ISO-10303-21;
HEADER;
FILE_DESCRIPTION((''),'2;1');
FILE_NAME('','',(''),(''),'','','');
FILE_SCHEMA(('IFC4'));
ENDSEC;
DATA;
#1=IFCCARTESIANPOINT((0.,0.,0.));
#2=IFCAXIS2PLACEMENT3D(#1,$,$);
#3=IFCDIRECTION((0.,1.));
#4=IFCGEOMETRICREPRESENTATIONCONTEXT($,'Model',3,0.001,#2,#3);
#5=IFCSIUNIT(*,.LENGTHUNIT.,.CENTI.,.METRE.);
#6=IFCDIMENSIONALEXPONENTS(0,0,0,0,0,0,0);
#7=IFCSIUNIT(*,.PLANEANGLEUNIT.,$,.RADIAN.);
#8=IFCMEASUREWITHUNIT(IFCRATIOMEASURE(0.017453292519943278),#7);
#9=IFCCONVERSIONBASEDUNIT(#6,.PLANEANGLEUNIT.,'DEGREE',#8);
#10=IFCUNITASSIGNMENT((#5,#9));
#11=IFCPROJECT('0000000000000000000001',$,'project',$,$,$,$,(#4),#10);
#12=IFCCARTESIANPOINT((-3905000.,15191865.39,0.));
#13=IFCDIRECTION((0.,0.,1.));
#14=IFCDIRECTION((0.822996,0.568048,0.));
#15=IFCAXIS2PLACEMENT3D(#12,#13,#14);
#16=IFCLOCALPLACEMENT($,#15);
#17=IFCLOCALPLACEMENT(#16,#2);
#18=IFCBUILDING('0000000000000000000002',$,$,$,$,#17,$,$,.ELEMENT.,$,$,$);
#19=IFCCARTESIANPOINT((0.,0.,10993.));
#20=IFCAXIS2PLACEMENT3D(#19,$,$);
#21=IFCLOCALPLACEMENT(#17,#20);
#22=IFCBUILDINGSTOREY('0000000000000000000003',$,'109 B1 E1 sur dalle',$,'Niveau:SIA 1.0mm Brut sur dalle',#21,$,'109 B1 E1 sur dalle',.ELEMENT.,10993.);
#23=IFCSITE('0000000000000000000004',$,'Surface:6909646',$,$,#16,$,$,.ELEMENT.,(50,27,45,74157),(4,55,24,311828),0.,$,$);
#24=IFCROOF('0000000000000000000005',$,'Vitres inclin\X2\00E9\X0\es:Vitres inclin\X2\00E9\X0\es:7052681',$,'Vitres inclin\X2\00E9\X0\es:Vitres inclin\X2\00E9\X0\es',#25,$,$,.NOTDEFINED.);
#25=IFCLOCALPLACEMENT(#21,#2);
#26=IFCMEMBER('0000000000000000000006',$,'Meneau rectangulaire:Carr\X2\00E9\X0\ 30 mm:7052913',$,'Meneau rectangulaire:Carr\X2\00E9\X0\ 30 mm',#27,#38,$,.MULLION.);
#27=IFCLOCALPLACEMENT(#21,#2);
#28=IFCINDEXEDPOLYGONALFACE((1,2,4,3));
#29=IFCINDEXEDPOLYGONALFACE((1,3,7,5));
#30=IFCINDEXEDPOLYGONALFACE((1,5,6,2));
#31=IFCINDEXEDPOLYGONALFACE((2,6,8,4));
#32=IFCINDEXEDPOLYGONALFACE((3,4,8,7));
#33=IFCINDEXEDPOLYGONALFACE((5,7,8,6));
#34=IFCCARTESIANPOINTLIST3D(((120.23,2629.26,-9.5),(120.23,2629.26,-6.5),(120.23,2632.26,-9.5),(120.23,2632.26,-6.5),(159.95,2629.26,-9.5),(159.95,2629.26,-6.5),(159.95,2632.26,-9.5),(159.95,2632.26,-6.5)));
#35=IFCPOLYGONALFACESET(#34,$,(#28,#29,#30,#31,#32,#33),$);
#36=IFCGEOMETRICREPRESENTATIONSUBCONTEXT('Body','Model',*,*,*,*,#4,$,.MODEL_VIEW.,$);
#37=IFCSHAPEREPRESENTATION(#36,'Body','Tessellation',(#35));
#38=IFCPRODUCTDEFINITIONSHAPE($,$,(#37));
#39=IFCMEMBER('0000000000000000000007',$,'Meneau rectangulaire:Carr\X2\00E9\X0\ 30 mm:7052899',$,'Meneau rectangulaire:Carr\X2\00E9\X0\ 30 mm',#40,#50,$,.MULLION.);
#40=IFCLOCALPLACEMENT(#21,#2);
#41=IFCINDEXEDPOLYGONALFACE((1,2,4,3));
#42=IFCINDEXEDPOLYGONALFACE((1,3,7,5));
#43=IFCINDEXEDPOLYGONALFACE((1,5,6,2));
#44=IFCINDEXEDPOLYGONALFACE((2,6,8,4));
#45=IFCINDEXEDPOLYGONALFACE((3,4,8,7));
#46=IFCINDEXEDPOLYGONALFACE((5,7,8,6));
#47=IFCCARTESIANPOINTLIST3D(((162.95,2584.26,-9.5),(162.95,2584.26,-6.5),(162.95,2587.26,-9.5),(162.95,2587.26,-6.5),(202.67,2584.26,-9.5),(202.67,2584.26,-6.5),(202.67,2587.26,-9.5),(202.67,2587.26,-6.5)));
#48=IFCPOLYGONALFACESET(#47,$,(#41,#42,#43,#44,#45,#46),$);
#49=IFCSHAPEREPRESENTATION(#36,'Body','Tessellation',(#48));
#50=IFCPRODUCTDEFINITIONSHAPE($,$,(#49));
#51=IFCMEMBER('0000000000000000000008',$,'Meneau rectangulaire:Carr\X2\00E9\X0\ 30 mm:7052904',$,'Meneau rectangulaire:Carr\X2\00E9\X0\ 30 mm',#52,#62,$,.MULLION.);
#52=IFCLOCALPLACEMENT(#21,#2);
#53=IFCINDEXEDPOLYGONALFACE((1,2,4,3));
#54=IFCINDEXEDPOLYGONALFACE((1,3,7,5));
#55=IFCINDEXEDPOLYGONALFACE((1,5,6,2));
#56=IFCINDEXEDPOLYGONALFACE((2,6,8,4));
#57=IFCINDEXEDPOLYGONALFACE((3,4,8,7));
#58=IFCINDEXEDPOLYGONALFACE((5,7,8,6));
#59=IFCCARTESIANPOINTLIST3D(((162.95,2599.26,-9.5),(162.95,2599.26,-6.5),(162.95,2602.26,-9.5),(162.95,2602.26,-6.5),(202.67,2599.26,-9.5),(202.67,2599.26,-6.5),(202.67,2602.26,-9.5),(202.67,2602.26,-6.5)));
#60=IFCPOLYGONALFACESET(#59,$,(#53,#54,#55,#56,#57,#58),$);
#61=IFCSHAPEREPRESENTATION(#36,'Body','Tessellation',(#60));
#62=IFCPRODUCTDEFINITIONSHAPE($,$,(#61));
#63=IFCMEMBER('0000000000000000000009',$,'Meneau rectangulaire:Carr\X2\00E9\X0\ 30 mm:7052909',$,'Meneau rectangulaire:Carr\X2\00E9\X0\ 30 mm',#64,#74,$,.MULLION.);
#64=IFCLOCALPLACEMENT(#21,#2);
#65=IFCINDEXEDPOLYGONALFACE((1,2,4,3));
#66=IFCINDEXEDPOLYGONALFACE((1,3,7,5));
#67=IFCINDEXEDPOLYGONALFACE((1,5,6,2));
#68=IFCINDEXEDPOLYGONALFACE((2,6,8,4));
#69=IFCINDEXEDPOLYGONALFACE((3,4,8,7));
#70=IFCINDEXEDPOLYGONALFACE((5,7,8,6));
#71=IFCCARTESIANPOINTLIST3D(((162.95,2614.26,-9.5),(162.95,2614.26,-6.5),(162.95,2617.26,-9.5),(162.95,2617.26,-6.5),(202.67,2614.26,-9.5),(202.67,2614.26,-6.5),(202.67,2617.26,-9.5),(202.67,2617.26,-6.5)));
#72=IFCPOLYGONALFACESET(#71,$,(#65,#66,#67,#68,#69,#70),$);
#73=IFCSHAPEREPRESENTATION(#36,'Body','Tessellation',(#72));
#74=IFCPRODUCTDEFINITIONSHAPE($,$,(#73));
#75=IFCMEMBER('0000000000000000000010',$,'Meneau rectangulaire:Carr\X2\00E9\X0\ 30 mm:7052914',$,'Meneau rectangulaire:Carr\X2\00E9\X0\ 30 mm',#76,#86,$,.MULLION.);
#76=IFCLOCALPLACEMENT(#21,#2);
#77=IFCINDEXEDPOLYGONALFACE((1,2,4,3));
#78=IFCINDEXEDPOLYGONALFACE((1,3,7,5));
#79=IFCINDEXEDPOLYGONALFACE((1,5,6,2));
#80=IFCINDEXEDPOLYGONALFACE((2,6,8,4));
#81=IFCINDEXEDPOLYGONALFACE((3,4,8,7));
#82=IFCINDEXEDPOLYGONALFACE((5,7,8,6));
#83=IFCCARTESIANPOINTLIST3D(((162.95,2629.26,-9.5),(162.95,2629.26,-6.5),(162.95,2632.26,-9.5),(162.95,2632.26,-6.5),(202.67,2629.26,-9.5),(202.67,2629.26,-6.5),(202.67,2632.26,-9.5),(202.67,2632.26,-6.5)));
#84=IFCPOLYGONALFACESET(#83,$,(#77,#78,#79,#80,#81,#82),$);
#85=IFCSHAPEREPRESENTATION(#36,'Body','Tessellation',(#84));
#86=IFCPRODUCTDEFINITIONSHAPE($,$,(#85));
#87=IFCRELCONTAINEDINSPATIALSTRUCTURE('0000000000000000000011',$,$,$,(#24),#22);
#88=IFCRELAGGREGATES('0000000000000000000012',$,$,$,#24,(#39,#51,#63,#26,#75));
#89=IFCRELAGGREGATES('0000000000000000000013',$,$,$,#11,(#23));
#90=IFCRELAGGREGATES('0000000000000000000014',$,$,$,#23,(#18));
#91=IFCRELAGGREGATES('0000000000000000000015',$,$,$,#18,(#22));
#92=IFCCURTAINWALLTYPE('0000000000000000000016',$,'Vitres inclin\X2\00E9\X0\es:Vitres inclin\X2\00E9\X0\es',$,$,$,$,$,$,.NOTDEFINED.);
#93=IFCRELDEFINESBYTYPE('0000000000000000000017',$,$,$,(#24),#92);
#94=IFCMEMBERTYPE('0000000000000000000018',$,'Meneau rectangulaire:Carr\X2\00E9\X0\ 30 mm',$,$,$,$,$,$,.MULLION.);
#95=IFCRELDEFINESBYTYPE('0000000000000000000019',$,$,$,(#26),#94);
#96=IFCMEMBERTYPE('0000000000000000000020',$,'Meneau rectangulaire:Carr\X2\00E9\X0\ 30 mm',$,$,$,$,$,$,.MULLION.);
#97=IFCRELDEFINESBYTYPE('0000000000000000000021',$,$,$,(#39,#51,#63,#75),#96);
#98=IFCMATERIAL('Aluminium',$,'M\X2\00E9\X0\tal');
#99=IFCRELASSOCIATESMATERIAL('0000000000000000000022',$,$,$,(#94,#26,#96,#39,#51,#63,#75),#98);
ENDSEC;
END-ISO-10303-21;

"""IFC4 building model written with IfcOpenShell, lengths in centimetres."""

from ifc_helpers import new_model, entity, si_unit, converted_unit, direction, frame, origin, place, context, subcontext, project, spatial, indexed_curve, outline, extrude, source, transform, mapped, material, type_object, type_shapes, element, aggregate, save


model = new_model("IFC4")

# Units and contexts
model_context = context("Model", 3, precision=0.001, world=origin(), true_north=direction((0.0, 1.0)))
body_context = subcontext(model_context, "Body", "Model", "MODEL_VIEW")
ifc_project = project(units=[si_unit("LENGTHUNIT", "METRE", prefix="CENTI"), converted_unit("PLANEANGLEUNIT", "DEGREE", entity("IfcRatioMeasure", 0.017453292519943278), si_unit("PLANEANGLEUNIT", "RADIAN"), dimensions=[0, 0, 0, 0, 0, 0, 0])], contexts=[model_context])

# Site, building, storey
site_placement = place(None, frame((-3905000.0, 15191865.39, 0.0), z_axis=(0.0, 0.0, 1.0), x_axis=(0.822996, 0.568048, 0.0)))
site = spatial("IfcSite", under=ifc_project, at=site_placement, Name="Surface:6909646", CompositionType="ELEMENT", RefLatitude=(50, 27, 45, 74157), RefLongitude=(4, 55, 24, 311828), RefElevation=0.0)
building_placement = place(site_placement, origin())
building = spatial("IfcBuilding", under=site, at=building_placement, CompositionType="ELEMENT")
storey_placement = place(building_placement, frame((0.0, 0.0, 10993.0)))
storey = spatial("IfcBuildingStorey", under=building, at=storey_placement, Name="109 B1 E1 sur dalle", ObjectType="Niveau:SIA 1.0mm Brut sur dalle", LongName="109 B1 E1 sur dalle", CompositionType="ELEMENT", Elevation=10993.0)

# Roof, members
curtain_wall_type = type_object("IfcCurtainWallType", Name="Vitres inclinées:Vitres inclinées", PredefinedType="NOTDEFINED")
roof_placement = place(storey_placement, frame((0.0, 0.0, -10993.0)))
roof = element("IfcRoof", 1, at=roof_placement, inside=storey, type_object=curtain_wall_type, Name="Vitres inclinées:Vitres inclinées:7052681", ObjectType="Vitres inclinées:Vitres inclinées", PredefinedType="NOTDEFINED")
ifc_material = material(Name="Aluminium", Category="Métal")
member_type_1 = type_object("IfcMemberType", Name="Meneau rectangulaire:Carré 30 mm", PredefinedType="MULLION", material=ifc_material)
shared_shape_1 = source(origin(), body_context, "Body", "SweptSolid", [
    extrude(outline(indexed_curve([(-1.5, -1.5), (1.5, -1.5), (1.5, 1.5), (-1.5, 1.5), (-1.5, -1.5)], self_intersect=False)), frame((0.0, 0.0, -39.72), z_axis=(0.0, 0.0, 1.0), x_axis=(0.0, -1.0, 0.0)), (0.0, 0.0, 1.0), 39.72),
])
type_shapes(member_type_1, [shared_shape_1])
member_1_placement = place(roof_placement, frame((120.23, 2630.76, 10985.0), z_axis=(-1.0, 0.0, 0.0), x_axis=(0.0, 1.0, 0.0)))
member_1 = element("IfcMember", 2, at=member_1_placement, type_object=member_type_1, material=ifc_material, Name="Meneau rectangulaire:Carré 30 mm:7052913", ObjectType="Meneau rectangulaire:Carré 30 mm", PredefinedType="MULLION", context=body_context, shape_type="MappedRepresentation", body=[
    mapped(shared_shape_1, transform((0.0, 0.0, 0.0), scale=1.0)),
])
member_type_2 = type_object("IfcMemberType", Name="Meneau rectangulaire:Carré 30 mm", PredefinedType="MULLION", material=ifc_material)
shared_shape_2 = source(origin(), body_context, "Body", "SweptSolid", [
    extrude(outline(indexed_curve([(-1.5, -1.5), (1.5, -1.5), (1.5, 1.5), (-1.5, 1.5), (-1.5, -1.5)], self_intersect=False)), frame((0.0, 0.0, -39.72), z_axis=(0.0, 0.0, 1.0), x_axis=(0.0, -1.0, 0.0)), (0.0, 0.0, 1.0), 39.72),
])
type_shapes(member_type_2, [shared_shape_2])
member_2_placement = place(roof_placement, frame((162.95, 2585.76, 10985.0), z_axis=(-1.0, 0.0, 0.0), x_axis=(0.0, 1.0, 0.0)))
member_2 = element("IfcMember", 3, at=member_2_placement, type_object=member_type_2, material=ifc_material, Name="Meneau rectangulaire:Carré 30 mm:7052899", ObjectType="Meneau rectangulaire:Carré 30 mm", PredefinedType="MULLION", context=body_context, shape_type="MappedRepresentation", body=[
    mapped(shared_shape_2, transform((0.0, 0.0, 0.0), scale=1.0)),
])
member_3_placement = place(roof_placement, frame((162.95, 2600.76, 10985.0), z_axis=(-1.0, 0.0, 0.0), x_axis=(0.0, 1.0, 0.0)))
member_3 = element("IfcMember", 4, at=member_3_placement, type_object=member_type_2, material=ifc_material, Name="Meneau rectangulaire:Carré 30 mm:7052904", ObjectType="Meneau rectangulaire:Carré 30 mm", PredefinedType="MULLION", context=body_context, shape_type="MappedRepresentation", body=[
    mapped(shared_shape_2, transform((0.0, 0.0, 0.0), scale=1.0)),
])
member_4_placement = place(roof_placement, frame((162.95, 2615.76, 10985.0), z_axis=(-1.0, 0.0, 0.0), x_axis=(0.0, 1.0, 0.0)))
member_4 = element("IfcMember", 5, at=member_4_placement, type_object=member_type_2, material=ifc_material, Name="Meneau rectangulaire:Carré 30 mm:7052909", ObjectType="Meneau rectangulaire:Carré 30 mm", PredefinedType="MULLION", context=body_context, shape_type="MappedRepresentation", body=[
    mapped(shared_shape_2, transform((0.0, 0.0, 0.0), scale=1.0)),
])
member_5_placement = place(roof_placement, frame((162.95, 2630.76, 10985.0), z_axis=(-1.0, 0.0, 0.0), x_axis=(0.0, 1.0, 0.0)))
member_5 = element("IfcMember", 6, at=member_5_placement, type_object=member_type_2, material=ifc_material, Name="Meneau rectangulaire:Carré 30 mm:7052914", ObjectType="Meneau rectangulaire:Carré 30 mm", PredefinedType="MULLION", context=body_context, shape_type="MappedRepresentation", body=[
    mapped(shared_shape_2, transform((0.0, 0.0, 0.0), scale=1.0)),
])
aggregate(roof, [member_2, member_3, member_4, member_1, member_5])

save(model, "model.ifc")
